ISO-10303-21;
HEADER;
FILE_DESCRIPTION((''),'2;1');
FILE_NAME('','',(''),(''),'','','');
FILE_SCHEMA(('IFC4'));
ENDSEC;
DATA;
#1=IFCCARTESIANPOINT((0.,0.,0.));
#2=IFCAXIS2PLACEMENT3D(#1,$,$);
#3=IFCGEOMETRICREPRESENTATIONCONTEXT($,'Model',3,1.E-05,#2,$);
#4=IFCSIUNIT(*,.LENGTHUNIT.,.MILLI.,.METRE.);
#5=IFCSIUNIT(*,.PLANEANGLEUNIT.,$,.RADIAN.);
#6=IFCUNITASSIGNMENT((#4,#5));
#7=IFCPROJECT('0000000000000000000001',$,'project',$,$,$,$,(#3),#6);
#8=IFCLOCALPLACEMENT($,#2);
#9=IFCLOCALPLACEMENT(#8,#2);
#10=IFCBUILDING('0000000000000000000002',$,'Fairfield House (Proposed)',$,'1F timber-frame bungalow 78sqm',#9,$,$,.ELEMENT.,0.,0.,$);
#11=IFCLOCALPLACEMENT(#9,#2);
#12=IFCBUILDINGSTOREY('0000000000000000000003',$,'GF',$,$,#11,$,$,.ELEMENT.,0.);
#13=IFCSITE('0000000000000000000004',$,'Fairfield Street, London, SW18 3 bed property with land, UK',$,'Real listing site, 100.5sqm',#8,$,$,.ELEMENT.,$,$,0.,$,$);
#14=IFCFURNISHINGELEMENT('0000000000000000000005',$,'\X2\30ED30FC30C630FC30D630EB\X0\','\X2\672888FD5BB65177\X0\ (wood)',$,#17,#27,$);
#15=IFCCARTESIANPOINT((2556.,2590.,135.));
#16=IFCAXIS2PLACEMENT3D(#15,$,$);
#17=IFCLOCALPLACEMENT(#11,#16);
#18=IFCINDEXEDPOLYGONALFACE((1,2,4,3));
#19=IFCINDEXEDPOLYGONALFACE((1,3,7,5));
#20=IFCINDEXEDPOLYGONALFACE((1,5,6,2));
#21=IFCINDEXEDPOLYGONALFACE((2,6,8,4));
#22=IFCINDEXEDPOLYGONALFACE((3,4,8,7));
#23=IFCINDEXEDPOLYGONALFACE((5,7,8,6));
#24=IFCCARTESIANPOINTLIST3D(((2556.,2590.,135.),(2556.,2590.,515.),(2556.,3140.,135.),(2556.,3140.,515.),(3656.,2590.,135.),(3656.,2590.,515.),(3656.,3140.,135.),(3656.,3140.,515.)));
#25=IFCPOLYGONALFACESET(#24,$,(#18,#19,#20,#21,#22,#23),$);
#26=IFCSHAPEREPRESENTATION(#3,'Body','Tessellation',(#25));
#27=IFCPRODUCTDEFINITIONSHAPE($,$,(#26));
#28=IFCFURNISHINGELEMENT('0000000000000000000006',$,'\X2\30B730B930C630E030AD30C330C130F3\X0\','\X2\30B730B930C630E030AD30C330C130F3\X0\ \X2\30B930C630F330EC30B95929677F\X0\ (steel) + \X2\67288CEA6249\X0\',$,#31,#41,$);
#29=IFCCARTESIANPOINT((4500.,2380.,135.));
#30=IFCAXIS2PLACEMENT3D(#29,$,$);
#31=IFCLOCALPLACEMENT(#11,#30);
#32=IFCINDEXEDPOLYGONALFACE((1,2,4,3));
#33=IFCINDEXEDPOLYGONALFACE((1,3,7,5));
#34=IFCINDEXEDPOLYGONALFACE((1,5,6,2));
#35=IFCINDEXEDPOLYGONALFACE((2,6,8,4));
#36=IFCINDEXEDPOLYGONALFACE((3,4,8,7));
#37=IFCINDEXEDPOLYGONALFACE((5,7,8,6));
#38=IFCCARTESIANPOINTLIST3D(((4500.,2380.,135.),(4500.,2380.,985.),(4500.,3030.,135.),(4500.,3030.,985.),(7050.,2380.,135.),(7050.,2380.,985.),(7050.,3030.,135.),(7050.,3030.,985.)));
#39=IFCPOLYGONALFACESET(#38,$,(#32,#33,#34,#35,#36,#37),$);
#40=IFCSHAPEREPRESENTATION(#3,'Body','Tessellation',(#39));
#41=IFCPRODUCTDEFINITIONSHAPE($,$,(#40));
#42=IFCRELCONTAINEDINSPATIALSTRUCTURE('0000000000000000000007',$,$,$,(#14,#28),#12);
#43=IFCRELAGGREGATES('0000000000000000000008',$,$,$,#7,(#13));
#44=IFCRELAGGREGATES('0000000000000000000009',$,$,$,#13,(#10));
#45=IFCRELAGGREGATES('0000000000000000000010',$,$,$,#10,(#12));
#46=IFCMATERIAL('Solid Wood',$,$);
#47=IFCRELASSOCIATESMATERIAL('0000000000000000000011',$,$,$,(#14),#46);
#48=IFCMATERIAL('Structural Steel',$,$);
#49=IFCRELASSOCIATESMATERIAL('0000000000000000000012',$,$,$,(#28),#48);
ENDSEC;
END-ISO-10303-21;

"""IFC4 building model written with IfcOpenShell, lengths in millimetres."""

from ifc_helpers import new_model, si_unit, frame, frame_2d, origin, place, context, project, spatial, rectangle, extrude, material, element, save


model = new_model("IFC4")

# Units and contexts
model_context = context("Model", 3, precision=1e-05, world=origin())
ifc_project = project(units=[si_unit("LENGTHUNIT", "METRE", prefix="MILLI"), si_unit("PLANEANGLEUNIT", "RADIAN")], contexts=[model_context])

# Site, building, storey
site_placement = place(None, origin())
site = spatial("IfcSite", under=ifc_project, at=site_placement, Name="Fairfield Street, London, SW18 3 bed property with land, UK", ObjectType="Real listing site, 100.5sqm", CompositionType="ELEMENT", RefElevation=0.0)
building_placement = place(site_placement, origin())
building = spatial("IfcBuilding", under=site, at=building_placement, Name="Fairfield House (Proposed)", ObjectType="1F timber-frame bungalow 78sqm", CompositionType="ELEMENT", ElevationOfRefHeight=0.0, ElevationOfTerrain=0.0)
storey_placement = place(building_placement, origin())
storey = spatial("IfcBuildingStorey", under=building, at=storey_placement, Name="GF", CompositionType="ELEMENT", Elevation=0.0)

# Shared definitions
ifc_material_1 = material(Name="Solid Wood")

# Furnishing elements
furnishing_1_placement = place(storey_placement, frame((2556.0, 2590.0, 135.0)))
element("IfcFurnishingElement", 1, at=furnishing_1_placement, inside=storey, material=ifc_material_1, Name="ローテーブル", Description="木製家具 (wood)", context=model_context, shape_type="SweptSolid", body=[
    extrude(rectangle(XDim=1100.0, YDim=550.0, at=frame_2d((550.0, 275.0))), frame((2556.0, 2590.0, 135.0)), (0.0, 0.0, 1.0), 380.0),
])
ifc_material_2 = material(Name="Structural Steel")
furnishing_2_placement = place(storey_placement, frame((4500.0, 2380.0, 135.0)))
element("IfcFurnishingElement", 2, at=furnishing_2_placement, inside=storey, material=ifc_material_2, Name="システムキッチン", Description="システムキッチン ステンレス天板 (steel) + 木質扉", context=model_context, shape_type="SweptSolid", body=[
    extrude(rectangle(XDim=2550.0, YDim=650.0, at=frame_2d((1275.0, 325.0))), frame((4500.0, 2380.0, 135.0)), (0.0, 0.0, 1.0), 850.0),
])

save(model, "model.ifc")
